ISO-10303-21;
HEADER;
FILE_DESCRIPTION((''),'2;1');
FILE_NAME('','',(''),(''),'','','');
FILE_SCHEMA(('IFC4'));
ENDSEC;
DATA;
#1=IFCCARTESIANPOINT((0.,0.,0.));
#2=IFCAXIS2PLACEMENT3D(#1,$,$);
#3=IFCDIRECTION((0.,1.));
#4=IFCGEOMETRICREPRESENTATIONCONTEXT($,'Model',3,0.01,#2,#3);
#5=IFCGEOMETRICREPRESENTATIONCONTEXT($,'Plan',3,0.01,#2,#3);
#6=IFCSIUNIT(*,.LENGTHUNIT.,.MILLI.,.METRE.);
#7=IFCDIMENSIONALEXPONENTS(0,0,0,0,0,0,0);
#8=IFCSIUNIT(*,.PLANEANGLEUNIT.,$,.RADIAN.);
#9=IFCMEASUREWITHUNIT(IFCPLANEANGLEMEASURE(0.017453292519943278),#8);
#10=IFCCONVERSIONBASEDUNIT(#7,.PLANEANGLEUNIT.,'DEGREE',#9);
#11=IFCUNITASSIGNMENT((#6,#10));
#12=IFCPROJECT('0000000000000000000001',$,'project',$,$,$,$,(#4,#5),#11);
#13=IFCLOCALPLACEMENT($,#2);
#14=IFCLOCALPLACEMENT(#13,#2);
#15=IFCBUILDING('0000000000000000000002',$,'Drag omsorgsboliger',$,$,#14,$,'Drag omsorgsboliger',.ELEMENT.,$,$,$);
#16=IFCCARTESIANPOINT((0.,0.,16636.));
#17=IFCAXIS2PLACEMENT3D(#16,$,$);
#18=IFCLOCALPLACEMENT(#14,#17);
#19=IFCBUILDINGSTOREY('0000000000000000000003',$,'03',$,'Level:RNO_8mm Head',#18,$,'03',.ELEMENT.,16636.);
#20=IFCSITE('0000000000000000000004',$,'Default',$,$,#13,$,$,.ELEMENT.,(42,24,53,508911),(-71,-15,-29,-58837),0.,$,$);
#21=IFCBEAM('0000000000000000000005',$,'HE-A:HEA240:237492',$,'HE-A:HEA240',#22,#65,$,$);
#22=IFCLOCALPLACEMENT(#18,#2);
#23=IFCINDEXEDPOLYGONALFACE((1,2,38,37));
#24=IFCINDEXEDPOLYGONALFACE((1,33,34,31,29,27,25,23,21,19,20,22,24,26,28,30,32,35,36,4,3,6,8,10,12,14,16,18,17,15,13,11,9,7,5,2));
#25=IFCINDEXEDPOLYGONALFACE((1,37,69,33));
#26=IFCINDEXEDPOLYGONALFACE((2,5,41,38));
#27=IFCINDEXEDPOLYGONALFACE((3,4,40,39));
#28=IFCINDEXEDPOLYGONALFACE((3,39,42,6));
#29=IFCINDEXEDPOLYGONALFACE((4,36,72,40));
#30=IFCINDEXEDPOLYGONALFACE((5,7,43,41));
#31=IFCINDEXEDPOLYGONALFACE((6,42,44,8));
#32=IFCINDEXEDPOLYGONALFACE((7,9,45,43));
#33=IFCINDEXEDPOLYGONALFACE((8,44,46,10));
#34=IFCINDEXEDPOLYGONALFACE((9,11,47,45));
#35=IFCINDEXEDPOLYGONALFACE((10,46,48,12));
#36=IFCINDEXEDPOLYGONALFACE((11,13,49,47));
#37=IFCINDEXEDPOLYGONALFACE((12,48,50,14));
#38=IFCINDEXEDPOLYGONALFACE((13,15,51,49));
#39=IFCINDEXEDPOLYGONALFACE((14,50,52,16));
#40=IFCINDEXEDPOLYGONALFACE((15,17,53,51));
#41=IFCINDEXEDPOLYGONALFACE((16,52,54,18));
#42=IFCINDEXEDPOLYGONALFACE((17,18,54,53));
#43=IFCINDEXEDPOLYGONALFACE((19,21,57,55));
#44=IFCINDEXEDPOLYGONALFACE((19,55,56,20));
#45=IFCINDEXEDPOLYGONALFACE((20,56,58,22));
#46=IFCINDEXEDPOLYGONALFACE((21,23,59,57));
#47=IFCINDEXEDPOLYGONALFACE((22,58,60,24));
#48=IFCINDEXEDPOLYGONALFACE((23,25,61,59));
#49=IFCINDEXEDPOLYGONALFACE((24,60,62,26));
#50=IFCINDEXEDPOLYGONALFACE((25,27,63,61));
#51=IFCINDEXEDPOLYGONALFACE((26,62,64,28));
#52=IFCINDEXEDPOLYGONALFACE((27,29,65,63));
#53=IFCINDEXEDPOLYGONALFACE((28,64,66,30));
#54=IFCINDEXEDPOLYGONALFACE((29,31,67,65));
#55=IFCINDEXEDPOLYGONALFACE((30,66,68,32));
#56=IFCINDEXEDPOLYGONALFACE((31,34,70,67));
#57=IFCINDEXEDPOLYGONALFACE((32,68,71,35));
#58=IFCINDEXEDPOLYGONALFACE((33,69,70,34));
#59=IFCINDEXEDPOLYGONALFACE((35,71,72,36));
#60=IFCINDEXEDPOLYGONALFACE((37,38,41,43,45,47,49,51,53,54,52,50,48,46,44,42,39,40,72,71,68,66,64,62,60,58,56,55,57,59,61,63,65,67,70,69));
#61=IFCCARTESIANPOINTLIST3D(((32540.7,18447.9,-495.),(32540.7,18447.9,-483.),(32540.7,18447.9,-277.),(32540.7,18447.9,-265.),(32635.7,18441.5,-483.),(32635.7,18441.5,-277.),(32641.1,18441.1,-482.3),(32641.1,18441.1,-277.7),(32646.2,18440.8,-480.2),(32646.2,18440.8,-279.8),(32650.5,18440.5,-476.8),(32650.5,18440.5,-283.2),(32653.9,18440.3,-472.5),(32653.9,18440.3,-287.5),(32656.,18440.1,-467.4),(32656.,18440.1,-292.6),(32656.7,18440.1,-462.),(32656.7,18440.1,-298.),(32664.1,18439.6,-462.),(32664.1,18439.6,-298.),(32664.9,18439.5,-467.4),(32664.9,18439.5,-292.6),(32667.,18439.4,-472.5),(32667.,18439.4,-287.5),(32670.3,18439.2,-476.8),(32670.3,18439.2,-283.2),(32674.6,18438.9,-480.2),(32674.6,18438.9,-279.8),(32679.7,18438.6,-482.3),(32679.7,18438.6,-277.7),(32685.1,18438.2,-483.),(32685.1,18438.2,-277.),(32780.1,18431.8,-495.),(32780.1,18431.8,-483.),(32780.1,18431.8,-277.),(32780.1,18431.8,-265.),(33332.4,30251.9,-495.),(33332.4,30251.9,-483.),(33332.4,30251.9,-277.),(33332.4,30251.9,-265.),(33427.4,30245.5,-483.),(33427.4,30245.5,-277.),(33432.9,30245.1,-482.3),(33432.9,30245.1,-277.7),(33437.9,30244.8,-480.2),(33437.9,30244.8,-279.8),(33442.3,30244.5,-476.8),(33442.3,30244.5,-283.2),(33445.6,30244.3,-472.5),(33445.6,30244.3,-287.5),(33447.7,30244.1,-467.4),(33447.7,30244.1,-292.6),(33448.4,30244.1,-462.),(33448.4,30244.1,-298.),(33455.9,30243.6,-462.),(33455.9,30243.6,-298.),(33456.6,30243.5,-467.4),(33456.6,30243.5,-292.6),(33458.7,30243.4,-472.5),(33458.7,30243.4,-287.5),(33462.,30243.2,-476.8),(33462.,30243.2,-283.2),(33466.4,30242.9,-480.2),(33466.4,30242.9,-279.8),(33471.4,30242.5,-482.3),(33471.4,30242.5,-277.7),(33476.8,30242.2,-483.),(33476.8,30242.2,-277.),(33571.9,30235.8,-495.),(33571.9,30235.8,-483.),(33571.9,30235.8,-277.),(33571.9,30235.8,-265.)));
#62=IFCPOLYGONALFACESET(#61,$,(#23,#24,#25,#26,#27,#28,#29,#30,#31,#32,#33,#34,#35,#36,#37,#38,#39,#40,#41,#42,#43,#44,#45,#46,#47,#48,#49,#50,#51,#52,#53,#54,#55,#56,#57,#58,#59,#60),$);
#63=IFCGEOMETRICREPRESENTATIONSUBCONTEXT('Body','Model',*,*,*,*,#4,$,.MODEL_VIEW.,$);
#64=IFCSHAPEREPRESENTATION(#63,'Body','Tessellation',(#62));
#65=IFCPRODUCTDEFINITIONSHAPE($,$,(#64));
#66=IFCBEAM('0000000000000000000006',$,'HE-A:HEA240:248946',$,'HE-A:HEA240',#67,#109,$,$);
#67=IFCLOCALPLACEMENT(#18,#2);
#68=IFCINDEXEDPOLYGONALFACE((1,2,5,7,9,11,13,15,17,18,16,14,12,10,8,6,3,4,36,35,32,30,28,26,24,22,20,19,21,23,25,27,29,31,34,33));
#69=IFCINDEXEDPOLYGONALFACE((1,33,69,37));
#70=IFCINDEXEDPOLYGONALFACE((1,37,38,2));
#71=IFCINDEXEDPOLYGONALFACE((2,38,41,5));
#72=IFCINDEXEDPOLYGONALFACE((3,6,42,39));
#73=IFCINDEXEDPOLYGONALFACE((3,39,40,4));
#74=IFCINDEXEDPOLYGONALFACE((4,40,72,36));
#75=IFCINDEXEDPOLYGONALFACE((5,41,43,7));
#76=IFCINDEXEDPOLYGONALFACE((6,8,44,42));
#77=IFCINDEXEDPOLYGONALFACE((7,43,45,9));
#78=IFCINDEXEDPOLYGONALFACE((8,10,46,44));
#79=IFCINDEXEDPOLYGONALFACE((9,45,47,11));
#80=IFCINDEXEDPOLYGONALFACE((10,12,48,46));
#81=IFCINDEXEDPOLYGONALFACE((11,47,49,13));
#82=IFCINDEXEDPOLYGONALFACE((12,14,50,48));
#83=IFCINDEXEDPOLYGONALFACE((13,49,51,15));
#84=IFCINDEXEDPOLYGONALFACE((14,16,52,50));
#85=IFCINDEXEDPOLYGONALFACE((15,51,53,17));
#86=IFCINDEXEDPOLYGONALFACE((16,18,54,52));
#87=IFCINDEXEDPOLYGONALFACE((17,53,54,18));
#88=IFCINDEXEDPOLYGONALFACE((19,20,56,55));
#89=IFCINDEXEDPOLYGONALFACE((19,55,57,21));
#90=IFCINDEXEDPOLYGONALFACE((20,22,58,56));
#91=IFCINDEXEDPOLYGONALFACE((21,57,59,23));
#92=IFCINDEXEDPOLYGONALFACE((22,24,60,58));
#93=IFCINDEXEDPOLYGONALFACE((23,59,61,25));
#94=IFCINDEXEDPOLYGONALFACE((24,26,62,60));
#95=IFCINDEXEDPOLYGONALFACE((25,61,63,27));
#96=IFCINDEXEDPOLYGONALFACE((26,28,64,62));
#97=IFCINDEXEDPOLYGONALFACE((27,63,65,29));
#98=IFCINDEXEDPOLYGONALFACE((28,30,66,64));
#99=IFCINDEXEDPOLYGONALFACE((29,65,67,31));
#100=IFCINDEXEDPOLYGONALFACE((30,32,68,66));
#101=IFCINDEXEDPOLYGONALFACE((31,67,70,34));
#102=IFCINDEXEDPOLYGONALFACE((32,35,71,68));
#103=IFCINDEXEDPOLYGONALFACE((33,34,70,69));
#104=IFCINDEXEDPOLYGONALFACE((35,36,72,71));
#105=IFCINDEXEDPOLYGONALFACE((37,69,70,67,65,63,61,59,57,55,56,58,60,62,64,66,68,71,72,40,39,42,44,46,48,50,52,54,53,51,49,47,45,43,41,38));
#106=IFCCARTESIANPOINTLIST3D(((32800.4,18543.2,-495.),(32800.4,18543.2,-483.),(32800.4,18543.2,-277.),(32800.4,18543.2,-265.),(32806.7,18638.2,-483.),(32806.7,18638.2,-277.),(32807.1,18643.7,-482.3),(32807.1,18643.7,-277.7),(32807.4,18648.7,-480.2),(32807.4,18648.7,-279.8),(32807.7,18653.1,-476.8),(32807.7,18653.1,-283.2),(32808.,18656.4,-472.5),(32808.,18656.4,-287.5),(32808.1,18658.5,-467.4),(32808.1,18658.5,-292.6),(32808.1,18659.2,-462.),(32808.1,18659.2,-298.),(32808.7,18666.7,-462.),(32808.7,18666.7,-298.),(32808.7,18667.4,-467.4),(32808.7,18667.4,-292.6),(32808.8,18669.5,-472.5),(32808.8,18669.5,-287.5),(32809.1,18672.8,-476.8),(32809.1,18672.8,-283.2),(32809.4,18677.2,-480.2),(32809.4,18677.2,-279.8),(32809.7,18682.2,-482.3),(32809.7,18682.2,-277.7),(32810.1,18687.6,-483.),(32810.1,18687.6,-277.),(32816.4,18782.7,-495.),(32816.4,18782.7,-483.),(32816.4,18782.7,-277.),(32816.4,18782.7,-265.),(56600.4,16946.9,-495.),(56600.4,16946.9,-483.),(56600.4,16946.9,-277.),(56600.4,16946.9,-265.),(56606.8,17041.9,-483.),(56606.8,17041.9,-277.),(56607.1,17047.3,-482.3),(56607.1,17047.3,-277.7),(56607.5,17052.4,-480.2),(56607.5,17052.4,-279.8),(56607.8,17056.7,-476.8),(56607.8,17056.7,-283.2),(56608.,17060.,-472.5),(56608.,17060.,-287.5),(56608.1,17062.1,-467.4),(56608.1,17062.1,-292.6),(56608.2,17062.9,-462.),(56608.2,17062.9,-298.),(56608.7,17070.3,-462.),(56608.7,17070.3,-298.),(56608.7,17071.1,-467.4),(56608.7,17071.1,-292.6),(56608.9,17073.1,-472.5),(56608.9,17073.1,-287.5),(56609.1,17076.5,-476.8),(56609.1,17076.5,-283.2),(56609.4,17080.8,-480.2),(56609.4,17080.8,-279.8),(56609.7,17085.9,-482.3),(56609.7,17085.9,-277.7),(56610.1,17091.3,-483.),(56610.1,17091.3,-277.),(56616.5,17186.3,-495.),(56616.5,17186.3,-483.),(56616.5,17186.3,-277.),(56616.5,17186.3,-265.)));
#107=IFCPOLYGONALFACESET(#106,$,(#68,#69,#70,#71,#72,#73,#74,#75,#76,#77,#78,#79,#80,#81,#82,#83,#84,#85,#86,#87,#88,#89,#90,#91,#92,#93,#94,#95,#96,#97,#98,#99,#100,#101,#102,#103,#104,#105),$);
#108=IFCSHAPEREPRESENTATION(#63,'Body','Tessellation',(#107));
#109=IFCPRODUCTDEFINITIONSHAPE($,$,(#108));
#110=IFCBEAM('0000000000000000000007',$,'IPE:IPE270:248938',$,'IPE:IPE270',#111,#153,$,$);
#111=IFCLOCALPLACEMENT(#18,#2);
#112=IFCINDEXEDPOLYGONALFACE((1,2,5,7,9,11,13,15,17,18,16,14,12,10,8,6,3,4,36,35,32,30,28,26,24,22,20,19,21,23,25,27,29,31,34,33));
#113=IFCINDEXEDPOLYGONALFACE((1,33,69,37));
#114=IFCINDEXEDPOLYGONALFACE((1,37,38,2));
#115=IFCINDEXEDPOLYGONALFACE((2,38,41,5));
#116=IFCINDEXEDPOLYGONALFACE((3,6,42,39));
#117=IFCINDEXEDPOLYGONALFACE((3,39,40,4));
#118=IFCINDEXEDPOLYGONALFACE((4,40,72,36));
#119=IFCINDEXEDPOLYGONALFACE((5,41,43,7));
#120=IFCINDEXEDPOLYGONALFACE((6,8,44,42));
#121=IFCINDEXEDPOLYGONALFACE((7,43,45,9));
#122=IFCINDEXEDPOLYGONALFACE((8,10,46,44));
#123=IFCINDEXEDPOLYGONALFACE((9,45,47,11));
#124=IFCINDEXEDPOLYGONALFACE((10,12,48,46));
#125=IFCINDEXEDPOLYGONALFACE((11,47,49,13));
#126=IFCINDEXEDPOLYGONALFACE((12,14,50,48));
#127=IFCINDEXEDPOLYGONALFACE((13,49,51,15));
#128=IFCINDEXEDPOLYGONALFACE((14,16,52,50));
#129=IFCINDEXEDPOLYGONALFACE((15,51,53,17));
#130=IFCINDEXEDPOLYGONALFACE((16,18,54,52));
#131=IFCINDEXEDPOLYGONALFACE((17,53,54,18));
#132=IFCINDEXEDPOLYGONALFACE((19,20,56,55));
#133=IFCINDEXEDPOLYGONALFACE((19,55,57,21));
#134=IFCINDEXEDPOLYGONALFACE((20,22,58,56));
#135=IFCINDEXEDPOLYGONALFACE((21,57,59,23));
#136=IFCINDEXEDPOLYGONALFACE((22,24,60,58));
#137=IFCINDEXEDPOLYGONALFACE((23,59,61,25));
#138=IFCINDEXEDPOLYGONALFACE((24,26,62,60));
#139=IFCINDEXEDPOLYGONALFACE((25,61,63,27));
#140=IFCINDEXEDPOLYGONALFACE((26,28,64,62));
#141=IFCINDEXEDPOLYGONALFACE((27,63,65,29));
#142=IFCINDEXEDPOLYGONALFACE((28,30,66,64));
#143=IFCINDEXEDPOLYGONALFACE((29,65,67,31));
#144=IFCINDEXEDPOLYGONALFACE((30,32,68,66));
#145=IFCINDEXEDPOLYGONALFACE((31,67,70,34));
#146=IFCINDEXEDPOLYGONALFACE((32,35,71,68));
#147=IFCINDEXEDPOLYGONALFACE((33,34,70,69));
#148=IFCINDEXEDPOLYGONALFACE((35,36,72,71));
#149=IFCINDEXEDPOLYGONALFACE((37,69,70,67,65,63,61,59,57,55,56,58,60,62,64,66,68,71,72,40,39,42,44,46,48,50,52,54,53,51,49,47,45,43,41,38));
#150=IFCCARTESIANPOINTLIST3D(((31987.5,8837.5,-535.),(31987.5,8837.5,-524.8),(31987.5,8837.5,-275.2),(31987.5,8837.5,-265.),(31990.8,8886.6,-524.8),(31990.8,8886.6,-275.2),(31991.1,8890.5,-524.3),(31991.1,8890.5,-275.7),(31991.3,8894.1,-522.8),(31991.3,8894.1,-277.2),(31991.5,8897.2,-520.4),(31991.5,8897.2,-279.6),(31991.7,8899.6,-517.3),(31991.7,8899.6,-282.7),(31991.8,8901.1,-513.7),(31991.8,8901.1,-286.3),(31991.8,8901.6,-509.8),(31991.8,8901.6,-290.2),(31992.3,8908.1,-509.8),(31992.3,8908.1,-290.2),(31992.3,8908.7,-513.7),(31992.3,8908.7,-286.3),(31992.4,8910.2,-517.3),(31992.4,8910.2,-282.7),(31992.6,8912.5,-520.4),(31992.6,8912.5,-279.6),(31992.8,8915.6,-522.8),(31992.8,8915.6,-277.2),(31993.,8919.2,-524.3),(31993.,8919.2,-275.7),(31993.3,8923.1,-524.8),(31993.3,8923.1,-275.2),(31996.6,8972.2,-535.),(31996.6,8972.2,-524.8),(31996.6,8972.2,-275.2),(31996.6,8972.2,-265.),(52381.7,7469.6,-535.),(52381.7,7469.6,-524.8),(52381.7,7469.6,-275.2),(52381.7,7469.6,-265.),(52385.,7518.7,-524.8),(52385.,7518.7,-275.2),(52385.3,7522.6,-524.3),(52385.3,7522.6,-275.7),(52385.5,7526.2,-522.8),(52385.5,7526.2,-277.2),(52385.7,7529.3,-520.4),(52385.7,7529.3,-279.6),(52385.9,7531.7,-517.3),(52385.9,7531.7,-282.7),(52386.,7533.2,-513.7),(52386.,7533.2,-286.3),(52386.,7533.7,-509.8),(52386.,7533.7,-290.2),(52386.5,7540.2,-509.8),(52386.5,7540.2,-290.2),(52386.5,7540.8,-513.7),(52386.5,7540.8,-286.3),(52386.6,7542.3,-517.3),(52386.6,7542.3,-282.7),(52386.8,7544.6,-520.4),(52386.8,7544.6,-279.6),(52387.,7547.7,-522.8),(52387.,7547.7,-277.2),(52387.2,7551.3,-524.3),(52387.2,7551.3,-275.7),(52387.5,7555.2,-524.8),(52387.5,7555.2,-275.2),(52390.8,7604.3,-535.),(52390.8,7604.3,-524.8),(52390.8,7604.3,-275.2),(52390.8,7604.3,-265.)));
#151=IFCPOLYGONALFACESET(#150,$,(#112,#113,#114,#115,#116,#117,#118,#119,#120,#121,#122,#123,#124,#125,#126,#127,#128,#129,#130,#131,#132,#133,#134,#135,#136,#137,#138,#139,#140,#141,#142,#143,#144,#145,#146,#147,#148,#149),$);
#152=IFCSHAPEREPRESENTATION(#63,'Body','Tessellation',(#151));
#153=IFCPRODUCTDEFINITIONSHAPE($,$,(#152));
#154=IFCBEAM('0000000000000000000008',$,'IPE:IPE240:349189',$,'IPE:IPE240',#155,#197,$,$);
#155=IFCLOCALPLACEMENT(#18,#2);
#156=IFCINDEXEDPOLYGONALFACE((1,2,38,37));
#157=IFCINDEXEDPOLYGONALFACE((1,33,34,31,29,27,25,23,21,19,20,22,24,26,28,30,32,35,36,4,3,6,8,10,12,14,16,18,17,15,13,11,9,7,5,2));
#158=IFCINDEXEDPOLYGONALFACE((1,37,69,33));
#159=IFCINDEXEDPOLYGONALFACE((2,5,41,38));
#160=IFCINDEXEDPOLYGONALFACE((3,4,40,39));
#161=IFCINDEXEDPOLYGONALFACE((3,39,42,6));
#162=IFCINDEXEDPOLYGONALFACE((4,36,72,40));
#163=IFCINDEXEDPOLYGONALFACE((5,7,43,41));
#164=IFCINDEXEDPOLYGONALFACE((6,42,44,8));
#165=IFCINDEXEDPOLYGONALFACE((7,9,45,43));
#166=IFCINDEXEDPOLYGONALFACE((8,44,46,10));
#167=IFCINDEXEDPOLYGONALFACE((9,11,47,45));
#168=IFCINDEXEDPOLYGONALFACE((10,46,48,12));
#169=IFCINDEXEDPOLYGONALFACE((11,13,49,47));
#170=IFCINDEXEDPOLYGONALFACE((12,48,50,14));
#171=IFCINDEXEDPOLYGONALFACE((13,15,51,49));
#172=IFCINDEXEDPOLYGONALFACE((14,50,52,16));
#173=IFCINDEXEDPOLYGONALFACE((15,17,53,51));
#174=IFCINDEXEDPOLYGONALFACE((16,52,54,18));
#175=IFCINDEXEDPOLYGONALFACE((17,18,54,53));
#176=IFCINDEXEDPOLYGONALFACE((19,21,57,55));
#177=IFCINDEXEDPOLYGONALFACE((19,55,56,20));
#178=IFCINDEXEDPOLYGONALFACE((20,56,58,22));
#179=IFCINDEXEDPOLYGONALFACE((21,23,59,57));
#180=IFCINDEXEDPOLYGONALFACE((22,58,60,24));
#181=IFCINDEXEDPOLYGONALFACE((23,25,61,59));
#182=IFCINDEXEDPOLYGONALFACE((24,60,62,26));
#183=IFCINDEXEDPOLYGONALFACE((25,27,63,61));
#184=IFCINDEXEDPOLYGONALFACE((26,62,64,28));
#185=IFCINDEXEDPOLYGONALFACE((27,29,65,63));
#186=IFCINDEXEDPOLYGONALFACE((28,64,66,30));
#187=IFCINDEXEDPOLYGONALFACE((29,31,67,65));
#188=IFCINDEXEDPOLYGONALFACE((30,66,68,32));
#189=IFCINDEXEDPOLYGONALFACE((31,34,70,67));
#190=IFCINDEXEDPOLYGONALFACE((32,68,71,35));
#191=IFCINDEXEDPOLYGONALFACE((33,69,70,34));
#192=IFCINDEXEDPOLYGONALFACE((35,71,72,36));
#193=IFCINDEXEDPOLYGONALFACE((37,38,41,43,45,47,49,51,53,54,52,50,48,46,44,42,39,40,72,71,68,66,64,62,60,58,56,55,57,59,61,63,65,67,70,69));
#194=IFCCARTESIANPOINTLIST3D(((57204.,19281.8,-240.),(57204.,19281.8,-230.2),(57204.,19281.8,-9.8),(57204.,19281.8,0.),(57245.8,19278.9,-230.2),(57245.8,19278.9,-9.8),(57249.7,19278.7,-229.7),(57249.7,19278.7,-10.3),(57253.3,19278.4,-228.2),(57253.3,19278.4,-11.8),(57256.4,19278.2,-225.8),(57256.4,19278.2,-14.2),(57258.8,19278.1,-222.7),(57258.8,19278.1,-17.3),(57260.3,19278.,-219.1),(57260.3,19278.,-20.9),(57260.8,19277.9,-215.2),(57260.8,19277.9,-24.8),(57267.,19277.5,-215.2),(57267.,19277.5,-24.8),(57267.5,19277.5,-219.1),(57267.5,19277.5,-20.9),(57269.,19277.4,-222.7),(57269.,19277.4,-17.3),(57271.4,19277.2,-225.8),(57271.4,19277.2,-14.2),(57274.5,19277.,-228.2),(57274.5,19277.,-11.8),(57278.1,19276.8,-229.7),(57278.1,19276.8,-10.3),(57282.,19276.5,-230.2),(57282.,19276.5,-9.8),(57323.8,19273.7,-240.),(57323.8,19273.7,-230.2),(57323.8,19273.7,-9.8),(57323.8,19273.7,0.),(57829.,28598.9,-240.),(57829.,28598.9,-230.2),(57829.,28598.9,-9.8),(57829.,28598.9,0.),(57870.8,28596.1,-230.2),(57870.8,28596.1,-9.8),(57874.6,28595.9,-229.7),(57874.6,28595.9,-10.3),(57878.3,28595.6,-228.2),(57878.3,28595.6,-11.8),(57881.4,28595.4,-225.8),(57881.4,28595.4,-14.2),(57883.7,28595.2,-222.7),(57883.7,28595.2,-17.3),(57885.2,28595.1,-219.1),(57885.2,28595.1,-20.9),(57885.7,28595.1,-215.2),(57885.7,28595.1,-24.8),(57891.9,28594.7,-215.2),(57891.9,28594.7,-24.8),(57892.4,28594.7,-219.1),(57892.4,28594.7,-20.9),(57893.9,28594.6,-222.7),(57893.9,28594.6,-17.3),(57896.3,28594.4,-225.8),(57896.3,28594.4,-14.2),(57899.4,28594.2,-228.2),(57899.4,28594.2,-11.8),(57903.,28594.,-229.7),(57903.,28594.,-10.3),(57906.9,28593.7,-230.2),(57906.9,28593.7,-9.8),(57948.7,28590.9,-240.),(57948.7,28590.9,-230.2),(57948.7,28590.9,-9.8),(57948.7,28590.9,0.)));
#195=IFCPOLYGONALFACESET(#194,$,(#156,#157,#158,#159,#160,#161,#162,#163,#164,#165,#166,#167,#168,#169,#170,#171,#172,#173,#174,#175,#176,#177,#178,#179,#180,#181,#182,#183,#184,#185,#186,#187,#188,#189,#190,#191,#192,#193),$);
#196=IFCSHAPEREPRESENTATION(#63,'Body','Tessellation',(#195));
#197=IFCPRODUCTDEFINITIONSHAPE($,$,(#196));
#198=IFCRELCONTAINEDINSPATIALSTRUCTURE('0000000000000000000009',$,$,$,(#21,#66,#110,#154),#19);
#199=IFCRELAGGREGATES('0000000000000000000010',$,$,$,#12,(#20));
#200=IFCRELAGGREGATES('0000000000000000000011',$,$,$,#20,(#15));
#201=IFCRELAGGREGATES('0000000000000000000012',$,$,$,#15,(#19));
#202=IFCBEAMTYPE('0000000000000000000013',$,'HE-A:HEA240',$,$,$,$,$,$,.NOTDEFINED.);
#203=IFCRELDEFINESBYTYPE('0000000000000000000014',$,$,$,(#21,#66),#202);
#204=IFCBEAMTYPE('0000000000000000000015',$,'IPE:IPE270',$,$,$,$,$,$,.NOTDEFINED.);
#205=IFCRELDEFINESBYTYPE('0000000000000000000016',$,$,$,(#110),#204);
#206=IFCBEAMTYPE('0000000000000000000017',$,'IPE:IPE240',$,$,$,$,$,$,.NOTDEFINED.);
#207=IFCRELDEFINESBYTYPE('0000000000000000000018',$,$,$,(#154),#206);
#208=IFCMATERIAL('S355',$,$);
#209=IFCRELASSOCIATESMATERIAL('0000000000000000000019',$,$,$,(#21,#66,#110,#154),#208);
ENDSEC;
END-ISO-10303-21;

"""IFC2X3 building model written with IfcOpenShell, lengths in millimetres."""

from ifc_helpers import new_model, entity, si_unit, converted_unit, direction, frame, frame_2d, origin, place, context, subcontext, project, spatial, i_section, extrude, material, type_object, element, save


model = new_model("IFC2X3")

# Units and contexts
model_context = context("Model", 3, precision=0.01, world=origin(), true_north=direction((0.0, 1.0)))
plan_context = context("Plan", 3, precision=0.01, world=origin(), true_north=direction((0.0, 1.0)))
body_context = subcontext(model_context, "Body", "Model", "MODEL_VIEW")
ifc_project = project(units=[si_unit("LENGTHUNIT", "METRE", prefix="MILLI"), converted_unit("PLANEANGLEUNIT", "DEGREE", entity("IfcPlaneAngleMeasure", 0.017453292519943278), si_unit("PLANEANGLEUNIT", "RADIAN"), dimensions=[0, 0, 0, 0, 0, 0, 0])], contexts=[model_context, plan_context])

# Site, building, storey
site_placement = place(None, origin())
site = spatial("IfcSite", under=ifc_project, at=site_placement, Name="Default", CompositionType="ELEMENT", RefLatitude=(42, 24, 53, 508911), RefLongitude=(-71, -15, -29, -58837), RefElevation=0.0)
building_placement = place(site_placement, origin())
building = spatial("IfcBuilding", under=site, at=building_placement, Name="Drag omsorgsboliger", LongName="Drag omsorgsboliger", CompositionType="ELEMENT")
storey_placement = place(building_placement, frame((0.0, 0.0, 16636.0)))
storey = spatial("IfcBuildingStorey", under=building, at=storey_placement, Name="03", ObjectType="Level:RNO_8mm Head", LongName="03", CompositionType="ELEMENT", Elevation=16636.0)

# Beams
ifc_material = material(Name="S355")
beam_type_1 = type_object("IfcBeamType", Name="HE-A:HEA240", PredefinedType="NOTDEFINED")
beam_1_placement = place(storey_placement, frame((32660.4, 18439.8, -265.0), z_axis=(0.0, 0.0, 1.0), x_axis=(0.066923, 0.997758, 0.0)))
element("IfcBeam", 1, at=beam_1_placement, inside=storey, type_object=beam_type_1, material=ifc_material, Name="HE-A:HEA240:237492", ObjectType="HE-A:HEA240", context=body_context, shape_type="SweptSolid", body=[
    extrude(i_section(OverallWidth=240.0, OverallDepth=230.0, WebThickness=7.5, FlangeThickness=12.0, FilletRadius=21.0, at=frame_2d((0.0, 0.0), x_axis=(0.0, 1.0))), frame((0.0, 0.0, -115.0), z_axis=(1.0, 0.0, 0.0), x_axis=(0.0, 0.0, -1.0)), (0.0, 0.0, 1.0), 11830.5),
])
beam_2_placement = place(storey_placement, frame((56608.5, 17066.6, -265.0), z_axis=(0.0, 0.0, 1.0), x_axis=(-0.997758, 0.066923, 0.0)))
element("IfcBeam", 2, at=beam_2_placement, inside=storey, type_object=beam_type_1, material=ifc_material, Name="HE-A:HEA240:248946", ObjectType="HE-A:HEA240", context=body_context, shape_type="SweptSolid", body=[
    extrude(i_section(OverallWidth=240.0, OverallDepth=230.0, WebThickness=7.5, FlangeThickness=12.0, FilletRadius=21.0, at=frame_2d((0.0, 0.0), x_axis=(0.0, 1.0))), frame((0.0, 0.0, -115.0), z_axis=(1.0, 0.0, 0.0), x_axis=(0.0, 0.0, -1.0)), (0.0, 0.0, 1.0), 23853.5),
])
beam_type_2 = type_object("IfcBeamType", Name="IPE:IPE270", PredefinedType="NOTDEFINED")
beam_3_placement = place(storey_placement, frame((52386.2, 7537.0, -265.0), z_axis=(0.0, 0.0, 1.0), x_axis=(-0.997758, 0.066923, 0.0)))
element("IfcBeam", 3, at=beam_3_placement, inside=storey, type_object=beam_type_2, material=ifc_material, Name="IPE:IPE270:248938", ObjectType="IPE:IPE270", context=body_context, shape_type="SweptSolid", body=[
    extrude(i_section(OverallWidth=135.0, OverallDepth=270.0, WebThickness=6.6, FlangeThickness=10.2, FilletRadius=15.0, at=frame_2d((0.0, 0.0), x_axis=(0.0, 1.0))), frame((0.0, 0.0, -135.0), z_axis=(1.0, 0.0, 0.0), x_axis=(0.0, 0.0, -1.0)), (0.0, 0.0, 1.0), 20440.0),
])
beam_type_3 = type_object("IfcBeamType", Name="IPE:IPE240", PredefinedType="NOTDEFINED")
beam_4_placement = place(storey_placement, frame((57264.1, 19280.4, 0.0), z_axis=(0.0, 0.0, 1.0), x_axis=(0.066923, 0.997758, 0.0)))
element("IfcBeam", 4, at=beam_4_placement, inside=storey, type_object=beam_type_3, material=ifc_material, Name="IPE:IPE240:349189", ObjectType="IPE:IPE240", context=body_context, shape_type="SweptSolid", body=[
    extrude(i_section(OverallWidth=120.0, OverallDepth=240.0, WebThickness=6.2, FlangeThickness=9.8, FilletRadius=15.0, at=frame_2d((0.0, 0.0), x_axis=(0.0, 1.0))), frame((-2.7, 0.0, -120.0), z_axis=(1.0, 0.0, 0.0), x_axis=(0.0, 0.0, -1.0)), (0.0, 0.0, 1.0), 9338.1),
])

save(model, "model.ifc")
